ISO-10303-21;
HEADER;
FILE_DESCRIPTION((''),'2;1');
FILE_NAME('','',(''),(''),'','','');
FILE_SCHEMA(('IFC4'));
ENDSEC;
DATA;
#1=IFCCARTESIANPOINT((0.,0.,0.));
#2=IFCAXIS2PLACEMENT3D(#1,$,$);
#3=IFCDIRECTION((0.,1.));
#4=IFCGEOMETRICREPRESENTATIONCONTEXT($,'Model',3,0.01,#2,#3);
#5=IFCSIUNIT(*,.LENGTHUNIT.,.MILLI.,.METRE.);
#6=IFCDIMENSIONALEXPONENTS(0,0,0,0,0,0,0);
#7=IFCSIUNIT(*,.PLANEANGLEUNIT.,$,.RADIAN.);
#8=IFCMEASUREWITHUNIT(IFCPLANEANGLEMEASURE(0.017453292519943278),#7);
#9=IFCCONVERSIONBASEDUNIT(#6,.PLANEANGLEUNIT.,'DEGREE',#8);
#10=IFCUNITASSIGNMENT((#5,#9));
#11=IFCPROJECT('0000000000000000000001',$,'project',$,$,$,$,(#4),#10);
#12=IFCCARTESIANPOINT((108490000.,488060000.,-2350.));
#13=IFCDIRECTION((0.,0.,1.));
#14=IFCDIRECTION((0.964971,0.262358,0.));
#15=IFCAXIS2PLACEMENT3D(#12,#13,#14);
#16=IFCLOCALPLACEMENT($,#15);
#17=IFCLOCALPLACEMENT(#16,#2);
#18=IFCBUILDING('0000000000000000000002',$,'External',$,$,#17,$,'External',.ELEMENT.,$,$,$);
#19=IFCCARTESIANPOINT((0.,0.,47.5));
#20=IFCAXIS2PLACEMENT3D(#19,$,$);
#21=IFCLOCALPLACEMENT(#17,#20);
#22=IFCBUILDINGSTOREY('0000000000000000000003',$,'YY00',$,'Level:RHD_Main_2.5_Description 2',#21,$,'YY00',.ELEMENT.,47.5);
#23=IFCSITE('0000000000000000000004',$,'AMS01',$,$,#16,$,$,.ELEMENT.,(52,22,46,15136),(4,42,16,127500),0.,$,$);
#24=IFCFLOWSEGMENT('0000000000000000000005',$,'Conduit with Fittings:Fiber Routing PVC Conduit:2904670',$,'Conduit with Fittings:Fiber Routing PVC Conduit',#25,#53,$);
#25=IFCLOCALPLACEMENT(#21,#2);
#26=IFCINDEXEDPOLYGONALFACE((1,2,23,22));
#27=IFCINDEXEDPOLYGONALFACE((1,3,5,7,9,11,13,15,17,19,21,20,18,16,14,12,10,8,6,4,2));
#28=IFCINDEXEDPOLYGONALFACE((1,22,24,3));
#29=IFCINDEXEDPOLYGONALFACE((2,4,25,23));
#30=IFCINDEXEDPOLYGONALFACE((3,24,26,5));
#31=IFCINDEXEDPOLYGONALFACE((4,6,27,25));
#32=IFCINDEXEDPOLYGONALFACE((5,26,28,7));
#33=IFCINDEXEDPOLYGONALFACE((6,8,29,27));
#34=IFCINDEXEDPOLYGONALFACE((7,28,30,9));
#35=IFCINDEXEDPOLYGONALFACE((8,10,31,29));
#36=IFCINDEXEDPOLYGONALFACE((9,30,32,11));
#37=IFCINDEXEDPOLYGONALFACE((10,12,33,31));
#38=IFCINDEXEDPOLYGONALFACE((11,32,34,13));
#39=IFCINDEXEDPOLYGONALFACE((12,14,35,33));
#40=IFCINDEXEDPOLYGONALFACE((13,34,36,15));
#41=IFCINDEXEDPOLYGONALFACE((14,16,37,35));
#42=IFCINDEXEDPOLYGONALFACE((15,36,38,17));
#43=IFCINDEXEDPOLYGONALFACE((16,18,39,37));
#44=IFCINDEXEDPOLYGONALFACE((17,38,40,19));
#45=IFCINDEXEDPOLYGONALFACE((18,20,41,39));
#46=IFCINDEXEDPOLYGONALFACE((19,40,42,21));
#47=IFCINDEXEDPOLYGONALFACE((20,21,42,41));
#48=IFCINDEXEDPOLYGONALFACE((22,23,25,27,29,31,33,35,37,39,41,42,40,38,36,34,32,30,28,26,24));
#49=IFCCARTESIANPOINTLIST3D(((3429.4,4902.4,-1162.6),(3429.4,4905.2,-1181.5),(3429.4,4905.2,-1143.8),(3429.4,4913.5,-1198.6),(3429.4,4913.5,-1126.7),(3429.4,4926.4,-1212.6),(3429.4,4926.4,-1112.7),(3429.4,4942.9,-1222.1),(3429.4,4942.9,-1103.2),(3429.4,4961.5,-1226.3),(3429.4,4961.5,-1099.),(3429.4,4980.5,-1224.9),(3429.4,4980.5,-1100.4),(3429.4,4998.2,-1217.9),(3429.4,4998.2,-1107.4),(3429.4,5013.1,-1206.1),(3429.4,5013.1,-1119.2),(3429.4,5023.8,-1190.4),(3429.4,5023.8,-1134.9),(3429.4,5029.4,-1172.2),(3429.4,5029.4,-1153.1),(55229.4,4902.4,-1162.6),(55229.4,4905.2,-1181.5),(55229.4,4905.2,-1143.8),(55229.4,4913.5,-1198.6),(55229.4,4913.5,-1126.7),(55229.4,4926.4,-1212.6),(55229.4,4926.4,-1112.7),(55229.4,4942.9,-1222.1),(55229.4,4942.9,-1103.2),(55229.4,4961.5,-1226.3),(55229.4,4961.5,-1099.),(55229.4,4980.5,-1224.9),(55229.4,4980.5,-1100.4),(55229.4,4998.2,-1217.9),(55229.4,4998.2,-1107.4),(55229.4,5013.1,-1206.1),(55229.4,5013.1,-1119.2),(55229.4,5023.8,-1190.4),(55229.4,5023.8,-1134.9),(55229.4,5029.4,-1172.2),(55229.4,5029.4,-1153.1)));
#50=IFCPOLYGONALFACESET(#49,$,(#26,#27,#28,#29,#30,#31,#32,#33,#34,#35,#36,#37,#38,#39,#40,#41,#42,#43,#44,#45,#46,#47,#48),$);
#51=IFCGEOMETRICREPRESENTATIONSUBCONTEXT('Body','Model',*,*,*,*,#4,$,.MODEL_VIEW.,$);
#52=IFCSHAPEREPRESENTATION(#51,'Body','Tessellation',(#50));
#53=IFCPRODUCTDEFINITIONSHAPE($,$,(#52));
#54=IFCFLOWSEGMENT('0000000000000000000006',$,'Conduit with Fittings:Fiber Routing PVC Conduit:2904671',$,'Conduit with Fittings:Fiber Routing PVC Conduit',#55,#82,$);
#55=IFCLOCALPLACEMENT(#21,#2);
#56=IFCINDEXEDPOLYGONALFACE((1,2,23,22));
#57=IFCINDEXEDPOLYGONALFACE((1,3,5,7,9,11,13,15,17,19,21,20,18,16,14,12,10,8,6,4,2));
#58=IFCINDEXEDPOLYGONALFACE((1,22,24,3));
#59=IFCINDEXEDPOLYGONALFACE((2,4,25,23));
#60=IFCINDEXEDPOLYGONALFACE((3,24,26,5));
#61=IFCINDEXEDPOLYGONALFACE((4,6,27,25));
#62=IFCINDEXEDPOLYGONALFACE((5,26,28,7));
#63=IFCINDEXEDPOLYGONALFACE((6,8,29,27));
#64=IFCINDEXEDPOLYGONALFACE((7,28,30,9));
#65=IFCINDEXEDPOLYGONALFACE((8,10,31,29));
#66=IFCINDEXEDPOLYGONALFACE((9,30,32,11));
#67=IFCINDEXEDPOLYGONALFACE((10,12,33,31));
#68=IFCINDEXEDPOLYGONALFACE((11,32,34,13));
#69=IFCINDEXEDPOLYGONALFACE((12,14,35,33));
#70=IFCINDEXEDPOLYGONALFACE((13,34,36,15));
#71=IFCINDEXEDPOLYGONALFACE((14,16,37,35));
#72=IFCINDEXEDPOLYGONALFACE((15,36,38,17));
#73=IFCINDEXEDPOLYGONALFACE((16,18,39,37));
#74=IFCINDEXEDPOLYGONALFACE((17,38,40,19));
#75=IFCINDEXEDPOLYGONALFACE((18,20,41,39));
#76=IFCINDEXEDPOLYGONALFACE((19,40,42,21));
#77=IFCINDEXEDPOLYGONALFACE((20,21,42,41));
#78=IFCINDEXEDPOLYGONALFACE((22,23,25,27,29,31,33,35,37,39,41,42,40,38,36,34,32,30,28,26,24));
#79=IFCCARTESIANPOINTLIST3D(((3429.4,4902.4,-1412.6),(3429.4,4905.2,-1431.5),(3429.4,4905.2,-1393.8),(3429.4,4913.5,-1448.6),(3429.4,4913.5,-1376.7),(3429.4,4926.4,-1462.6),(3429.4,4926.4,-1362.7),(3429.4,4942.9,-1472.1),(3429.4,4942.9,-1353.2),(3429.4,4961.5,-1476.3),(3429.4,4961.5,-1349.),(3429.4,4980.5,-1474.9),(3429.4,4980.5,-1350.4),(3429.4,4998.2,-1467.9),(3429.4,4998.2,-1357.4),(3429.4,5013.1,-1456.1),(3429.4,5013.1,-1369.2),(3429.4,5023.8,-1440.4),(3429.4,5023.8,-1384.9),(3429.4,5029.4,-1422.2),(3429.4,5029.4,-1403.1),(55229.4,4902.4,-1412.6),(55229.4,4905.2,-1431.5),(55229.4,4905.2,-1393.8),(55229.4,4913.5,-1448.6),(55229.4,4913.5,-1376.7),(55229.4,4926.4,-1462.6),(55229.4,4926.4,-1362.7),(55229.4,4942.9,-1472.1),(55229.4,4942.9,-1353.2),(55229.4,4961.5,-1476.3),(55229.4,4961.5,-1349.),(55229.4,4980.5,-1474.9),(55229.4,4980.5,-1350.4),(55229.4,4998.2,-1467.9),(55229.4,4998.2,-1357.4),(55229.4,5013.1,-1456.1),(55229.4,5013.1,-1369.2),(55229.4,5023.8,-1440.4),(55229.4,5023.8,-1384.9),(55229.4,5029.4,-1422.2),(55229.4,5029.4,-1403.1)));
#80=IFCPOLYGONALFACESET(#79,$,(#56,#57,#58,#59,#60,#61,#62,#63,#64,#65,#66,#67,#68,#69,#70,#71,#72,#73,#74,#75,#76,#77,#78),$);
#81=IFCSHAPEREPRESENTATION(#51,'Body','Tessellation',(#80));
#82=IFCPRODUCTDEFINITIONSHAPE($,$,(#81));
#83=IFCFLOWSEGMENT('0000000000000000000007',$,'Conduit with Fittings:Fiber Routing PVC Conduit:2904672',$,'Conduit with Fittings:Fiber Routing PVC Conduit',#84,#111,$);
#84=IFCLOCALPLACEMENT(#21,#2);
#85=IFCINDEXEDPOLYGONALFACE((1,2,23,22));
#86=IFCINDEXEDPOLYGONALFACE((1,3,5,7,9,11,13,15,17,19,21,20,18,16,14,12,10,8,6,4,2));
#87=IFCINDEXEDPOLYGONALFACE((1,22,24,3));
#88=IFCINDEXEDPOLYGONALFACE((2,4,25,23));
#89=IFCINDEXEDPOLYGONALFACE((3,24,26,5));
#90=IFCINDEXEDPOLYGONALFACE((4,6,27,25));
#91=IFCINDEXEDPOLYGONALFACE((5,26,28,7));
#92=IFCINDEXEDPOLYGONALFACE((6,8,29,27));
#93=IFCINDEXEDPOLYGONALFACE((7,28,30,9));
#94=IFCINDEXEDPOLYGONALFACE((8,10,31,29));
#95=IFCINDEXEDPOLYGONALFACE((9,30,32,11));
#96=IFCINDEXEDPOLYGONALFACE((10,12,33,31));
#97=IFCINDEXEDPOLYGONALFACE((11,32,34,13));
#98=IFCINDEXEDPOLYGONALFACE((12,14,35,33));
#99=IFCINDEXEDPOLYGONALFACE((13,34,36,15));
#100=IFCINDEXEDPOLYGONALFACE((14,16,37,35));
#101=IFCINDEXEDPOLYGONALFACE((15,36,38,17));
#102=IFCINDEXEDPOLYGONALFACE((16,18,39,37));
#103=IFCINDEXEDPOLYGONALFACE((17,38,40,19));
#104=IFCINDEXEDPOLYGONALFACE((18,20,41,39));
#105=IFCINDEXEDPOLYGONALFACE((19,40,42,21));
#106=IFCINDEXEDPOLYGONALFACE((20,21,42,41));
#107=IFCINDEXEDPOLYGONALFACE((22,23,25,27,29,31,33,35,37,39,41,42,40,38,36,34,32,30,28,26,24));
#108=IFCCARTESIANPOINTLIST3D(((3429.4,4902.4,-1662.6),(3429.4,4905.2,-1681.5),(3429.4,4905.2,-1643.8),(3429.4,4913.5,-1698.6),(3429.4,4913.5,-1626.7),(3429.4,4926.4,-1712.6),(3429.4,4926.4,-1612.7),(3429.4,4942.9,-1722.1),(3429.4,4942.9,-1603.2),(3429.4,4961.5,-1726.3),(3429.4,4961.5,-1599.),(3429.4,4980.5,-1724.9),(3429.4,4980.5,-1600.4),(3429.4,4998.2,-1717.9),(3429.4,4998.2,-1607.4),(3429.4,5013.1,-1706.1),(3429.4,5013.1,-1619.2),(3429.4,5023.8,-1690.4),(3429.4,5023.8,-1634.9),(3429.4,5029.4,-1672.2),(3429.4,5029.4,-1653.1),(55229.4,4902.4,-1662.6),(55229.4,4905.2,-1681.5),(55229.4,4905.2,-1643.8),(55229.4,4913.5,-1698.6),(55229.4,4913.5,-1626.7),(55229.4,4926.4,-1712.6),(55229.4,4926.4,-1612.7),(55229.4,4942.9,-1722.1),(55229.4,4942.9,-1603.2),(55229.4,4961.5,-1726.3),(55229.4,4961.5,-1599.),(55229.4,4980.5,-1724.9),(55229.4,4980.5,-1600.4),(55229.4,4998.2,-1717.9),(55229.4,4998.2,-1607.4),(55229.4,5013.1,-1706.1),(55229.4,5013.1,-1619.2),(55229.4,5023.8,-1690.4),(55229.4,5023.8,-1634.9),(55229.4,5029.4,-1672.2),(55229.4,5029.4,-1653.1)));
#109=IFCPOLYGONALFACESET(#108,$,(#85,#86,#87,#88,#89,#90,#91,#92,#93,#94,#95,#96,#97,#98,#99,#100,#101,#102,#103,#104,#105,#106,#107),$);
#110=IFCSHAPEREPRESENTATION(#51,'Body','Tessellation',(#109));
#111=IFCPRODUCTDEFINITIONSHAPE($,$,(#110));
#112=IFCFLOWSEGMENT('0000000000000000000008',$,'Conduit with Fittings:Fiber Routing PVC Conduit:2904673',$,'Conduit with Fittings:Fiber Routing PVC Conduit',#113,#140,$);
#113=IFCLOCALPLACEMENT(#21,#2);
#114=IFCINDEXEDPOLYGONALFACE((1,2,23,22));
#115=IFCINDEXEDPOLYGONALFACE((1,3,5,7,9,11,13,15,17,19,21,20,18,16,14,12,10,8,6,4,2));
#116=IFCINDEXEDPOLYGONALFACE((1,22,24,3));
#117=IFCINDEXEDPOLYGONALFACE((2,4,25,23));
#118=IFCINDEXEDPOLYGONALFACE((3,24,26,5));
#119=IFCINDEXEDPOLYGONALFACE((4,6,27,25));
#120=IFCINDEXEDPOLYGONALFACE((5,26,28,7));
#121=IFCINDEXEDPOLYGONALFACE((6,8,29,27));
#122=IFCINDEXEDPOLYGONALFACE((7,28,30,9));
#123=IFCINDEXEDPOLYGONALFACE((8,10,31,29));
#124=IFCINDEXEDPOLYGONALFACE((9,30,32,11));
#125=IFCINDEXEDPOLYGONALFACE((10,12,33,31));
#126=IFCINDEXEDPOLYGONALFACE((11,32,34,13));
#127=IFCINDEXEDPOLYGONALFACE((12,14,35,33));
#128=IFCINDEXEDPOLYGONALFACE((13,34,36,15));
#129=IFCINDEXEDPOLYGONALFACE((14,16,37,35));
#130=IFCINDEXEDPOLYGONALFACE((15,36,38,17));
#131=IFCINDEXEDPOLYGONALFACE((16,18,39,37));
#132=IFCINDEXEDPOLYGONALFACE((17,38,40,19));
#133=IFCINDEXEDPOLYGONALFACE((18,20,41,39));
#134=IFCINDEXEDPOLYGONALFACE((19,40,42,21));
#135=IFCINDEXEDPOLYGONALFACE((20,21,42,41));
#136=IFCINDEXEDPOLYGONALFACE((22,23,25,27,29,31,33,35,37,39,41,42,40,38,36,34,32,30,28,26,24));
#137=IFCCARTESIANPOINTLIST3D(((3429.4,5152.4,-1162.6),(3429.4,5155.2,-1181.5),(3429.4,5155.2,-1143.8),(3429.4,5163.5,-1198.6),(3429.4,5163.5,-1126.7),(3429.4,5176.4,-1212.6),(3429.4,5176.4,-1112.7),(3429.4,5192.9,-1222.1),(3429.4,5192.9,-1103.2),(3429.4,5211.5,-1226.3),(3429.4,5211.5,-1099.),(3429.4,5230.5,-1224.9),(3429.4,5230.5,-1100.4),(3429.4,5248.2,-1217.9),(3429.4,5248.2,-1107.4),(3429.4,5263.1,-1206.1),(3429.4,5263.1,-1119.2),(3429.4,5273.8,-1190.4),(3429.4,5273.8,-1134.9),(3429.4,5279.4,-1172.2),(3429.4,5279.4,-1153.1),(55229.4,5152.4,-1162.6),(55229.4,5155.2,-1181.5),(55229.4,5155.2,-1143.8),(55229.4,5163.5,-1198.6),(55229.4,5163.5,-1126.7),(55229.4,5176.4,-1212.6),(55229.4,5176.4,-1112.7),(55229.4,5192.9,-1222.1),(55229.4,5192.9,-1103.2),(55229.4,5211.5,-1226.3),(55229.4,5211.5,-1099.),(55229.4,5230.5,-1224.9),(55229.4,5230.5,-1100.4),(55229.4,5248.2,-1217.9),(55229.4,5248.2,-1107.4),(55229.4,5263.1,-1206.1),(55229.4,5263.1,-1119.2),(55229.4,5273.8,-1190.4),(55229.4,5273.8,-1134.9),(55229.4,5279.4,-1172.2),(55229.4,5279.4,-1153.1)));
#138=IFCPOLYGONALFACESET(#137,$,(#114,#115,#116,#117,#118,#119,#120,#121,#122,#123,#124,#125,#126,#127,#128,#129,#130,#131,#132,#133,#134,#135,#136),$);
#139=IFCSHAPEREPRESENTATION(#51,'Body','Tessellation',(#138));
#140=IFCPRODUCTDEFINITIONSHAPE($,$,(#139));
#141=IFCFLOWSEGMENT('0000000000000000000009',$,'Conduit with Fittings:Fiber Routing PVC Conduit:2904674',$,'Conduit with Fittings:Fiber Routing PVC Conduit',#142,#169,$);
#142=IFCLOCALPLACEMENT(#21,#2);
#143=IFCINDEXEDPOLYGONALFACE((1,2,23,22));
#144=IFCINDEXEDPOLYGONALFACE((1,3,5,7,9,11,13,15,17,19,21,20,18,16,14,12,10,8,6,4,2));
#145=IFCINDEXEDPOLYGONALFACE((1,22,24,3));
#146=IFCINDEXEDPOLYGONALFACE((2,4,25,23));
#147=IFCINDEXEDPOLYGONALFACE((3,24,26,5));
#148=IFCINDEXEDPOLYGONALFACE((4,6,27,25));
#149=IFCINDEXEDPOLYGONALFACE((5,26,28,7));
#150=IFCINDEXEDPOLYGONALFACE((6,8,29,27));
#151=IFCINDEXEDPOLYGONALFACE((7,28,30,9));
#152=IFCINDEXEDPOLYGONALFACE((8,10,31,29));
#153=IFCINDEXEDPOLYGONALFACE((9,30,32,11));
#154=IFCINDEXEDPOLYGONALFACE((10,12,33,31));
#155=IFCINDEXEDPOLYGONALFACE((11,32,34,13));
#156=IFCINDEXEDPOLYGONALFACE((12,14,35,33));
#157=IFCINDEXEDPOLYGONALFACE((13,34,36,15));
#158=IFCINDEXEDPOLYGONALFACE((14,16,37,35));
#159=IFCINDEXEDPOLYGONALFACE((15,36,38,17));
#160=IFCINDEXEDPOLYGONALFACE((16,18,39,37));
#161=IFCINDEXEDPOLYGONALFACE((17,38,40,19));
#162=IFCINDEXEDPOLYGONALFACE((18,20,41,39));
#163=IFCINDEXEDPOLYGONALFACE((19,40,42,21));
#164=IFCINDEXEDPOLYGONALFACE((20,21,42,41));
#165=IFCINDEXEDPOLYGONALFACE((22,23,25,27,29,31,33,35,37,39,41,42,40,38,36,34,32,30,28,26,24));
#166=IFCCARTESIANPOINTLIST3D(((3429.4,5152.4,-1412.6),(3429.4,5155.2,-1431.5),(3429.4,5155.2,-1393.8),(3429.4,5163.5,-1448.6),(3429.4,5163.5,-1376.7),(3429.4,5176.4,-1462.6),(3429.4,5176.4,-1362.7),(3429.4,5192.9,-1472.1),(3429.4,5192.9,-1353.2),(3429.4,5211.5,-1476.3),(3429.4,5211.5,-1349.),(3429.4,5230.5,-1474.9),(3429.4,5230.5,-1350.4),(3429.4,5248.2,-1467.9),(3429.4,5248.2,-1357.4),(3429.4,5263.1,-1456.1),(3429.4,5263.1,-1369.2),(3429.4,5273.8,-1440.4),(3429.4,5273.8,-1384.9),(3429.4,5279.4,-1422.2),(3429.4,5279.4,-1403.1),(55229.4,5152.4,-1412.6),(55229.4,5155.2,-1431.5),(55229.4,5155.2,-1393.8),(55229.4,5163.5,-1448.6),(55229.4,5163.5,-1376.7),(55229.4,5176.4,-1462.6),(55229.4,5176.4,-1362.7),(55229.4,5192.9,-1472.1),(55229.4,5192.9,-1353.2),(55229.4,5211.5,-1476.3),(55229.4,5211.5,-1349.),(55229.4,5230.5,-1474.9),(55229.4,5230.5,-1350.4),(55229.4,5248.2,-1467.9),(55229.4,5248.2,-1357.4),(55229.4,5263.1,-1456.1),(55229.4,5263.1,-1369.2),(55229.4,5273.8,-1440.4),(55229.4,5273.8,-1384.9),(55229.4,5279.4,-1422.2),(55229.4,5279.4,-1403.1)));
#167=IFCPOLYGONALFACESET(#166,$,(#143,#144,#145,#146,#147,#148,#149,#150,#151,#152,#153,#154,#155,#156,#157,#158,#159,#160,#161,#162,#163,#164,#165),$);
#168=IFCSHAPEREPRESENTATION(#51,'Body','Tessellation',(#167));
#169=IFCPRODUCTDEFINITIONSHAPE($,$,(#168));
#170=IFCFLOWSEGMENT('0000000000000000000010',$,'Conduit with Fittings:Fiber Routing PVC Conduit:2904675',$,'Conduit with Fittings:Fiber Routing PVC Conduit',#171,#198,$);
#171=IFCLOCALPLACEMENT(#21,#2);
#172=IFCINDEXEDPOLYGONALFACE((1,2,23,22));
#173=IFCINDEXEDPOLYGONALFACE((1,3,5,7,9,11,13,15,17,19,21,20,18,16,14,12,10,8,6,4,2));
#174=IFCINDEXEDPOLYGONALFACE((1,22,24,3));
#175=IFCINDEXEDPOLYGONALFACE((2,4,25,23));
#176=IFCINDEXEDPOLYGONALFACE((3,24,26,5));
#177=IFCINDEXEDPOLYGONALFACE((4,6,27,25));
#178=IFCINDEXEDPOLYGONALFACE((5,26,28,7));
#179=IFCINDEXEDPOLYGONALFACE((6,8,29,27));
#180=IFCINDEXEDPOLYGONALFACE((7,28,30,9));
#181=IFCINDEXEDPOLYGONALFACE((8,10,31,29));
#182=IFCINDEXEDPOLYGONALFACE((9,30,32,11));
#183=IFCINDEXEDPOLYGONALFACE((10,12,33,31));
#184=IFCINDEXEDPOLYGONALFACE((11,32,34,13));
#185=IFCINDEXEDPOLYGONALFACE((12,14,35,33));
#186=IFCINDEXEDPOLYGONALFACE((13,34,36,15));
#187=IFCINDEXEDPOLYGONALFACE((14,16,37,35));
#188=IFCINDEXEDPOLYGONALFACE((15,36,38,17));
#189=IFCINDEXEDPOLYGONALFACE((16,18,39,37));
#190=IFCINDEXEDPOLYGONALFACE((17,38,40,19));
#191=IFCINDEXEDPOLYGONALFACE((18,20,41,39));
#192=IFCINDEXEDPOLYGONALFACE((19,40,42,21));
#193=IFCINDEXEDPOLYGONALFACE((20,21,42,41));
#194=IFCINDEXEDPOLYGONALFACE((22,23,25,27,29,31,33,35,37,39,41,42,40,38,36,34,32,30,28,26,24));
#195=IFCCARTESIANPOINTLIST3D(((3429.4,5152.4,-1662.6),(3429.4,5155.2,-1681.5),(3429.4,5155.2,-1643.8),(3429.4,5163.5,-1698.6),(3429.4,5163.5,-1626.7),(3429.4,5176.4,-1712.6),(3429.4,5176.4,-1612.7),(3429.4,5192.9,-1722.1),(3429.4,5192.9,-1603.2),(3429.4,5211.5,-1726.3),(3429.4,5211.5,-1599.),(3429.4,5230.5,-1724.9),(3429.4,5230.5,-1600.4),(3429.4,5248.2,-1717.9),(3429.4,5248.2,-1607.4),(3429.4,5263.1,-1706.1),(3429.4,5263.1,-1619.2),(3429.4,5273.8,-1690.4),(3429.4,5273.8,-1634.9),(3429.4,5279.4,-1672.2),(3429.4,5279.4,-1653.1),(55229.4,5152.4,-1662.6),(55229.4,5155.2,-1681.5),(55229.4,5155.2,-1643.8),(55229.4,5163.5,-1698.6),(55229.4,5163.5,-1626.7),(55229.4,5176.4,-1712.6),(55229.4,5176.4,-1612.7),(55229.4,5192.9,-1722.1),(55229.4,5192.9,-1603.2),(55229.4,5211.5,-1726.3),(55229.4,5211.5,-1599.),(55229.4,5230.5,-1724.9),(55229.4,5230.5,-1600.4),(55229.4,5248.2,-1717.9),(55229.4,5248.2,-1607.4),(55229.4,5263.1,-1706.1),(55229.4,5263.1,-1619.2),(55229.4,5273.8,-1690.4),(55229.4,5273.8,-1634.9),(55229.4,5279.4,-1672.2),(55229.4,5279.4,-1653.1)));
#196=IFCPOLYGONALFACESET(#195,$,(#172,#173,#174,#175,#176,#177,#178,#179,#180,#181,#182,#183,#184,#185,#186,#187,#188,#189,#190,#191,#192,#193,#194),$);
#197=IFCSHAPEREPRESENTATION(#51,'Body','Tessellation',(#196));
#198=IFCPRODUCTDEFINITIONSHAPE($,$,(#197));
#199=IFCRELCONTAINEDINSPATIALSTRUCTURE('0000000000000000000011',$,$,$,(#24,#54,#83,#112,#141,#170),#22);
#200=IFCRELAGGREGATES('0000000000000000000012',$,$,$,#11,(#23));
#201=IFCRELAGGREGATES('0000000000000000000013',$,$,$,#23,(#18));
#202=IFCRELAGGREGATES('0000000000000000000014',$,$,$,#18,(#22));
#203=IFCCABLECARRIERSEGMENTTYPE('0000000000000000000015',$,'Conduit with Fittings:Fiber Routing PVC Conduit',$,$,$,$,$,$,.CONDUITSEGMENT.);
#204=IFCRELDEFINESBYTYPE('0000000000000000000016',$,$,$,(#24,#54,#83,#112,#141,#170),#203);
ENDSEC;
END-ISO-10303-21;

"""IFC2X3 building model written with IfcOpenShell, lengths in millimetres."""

from ifc_helpers import new_model, entity, si_unit, converted_unit, direction, frame, frame_2d, origin, origin_2d_with_axis, place, context, subcontext, project, spatial, circle, extrude, type_object, element, save


model = new_model("IFC2X3")

# Units and contexts
model_context = context("Model", 3, precision=0.01, world=origin(), true_north=direction((0.0, 1.0)))
body_context = subcontext(model_context, "Body", "Model", "MODEL_VIEW")
ifc_project = project(units=[si_unit("LENGTHUNIT", "METRE", prefix="MILLI"), converted_unit("PLANEANGLEUNIT", "DEGREE", entity("IfcPlaneAngleMeasure", 0.017453292519943278), si_unit("PLANEANGLEUNIT", "RADIAN"), dimensions=[0, 0, 0, 0, 0, 0, 0])], contexts=[model_context])

# Site, building, storey
site_placement = place(None, frame((108490000.0, 488060000.0, -2350.0), z_axis=(0.0, 0.0, 1.0), x_axis=(0.964971, 0.262358, 0.0)))
site = spatial("IfcSite", under=ifc_project, at=site_placement, Name="AMS01", CompositionType="ELEMENT", RefLatitude=(52, 22, 46, 15136), RefLongitude=(4, 42, 16, 127500), RefElevation=0.0)
building_placement = place(site_placement, origin())
building = spatial("IfcBuilding", under=site, at=building_placement, Name="External", LongName="External", CompositionType="ELEMENT")
storey_placement = place(building_placement, frame((0.0, 0.0, 47.5)))
storey = spatial("IfcBuildingStorey", under=building, at=storey_placement, Name="YY00", ObjectType="Level:RHD_Main_2.5_Description 2", LongName="YY00", CompositionType="ELEMENT", Elevation=47.5)

# Flow segments
cable_carrier_segment_type = type_object("IfcCableCarrierSegmentType", Name="Conduit with Fittings:Fiber Routing PVC Conduit", PredefinedType="CONDUITSEGMENT")
flow_segment_1_placement = place(storey_placement, origin())
element("IfcFlowSegment", 1, at=flow_segment_1_placement, inside=storey, type_object=cable_carrier_segment_type, Name="Conduit with Fittings:Fiber Routing PVC Conduit:2904670", ObjectType="Conduit with Fittings:Fiber Routing PVC Conduit", context=body_context, shape_type="SweptSolid", body=[
    extrude(circle(Radius=63.9, at=frame_2d((0.0, 0.0), x_axis=(1.0, 0.0))), frame((3429.4, 4966.3, -1162.6), z_axis=(1.0, 0.0, 0.0), x_axis=(0.0, -1.0, 0.0)), (0.0, 0.0, 1.0), 51800.0),
])
flow_segment_2_placement = place(storey_placement, origin())
element("IfcFlowSegment", 2, at=flow_segment_2_placement, inside=storey, type_object=cable_carrier_segment_type, Name="Conduit with Fittings:Fiber Routing PVC Conduit:2904671", ObjectType="Conduit with Fittings:Fiber Routing PVC Conduit", context=body_context, shape_type="SweptSolid", body=[
    extrude(circle(Radius=63.9, at=origin_2d_with_axis()), frame((3429.4, 4966.3, -1412.6), z_axis=(1.0, 0.0, 0.0), x_axis=(0.0, -1.0, 0.0)), (0.0, 0.0, 1.0), 51800.0),
])
flow_segment_3_placement = place(storey_placement, origin())
element("IfcFlowSegment", 3, at=flow_segment_3_placement, inside=storey, type_object=cable_carrier_segment_type, Name="Conduit with Fittings:Fiber Routing PVC Conduit:2904672", ObjectType="Conduit with Fittings:Fiber Routing PVC Conduit", context=body_context, shape_type="SweptSolid", body=[
    extrude(circle(Radius=63.9, at=origin_2d_with_axis()), frame((3429.4, 4966.3, -1662.6), z_axis=(1.0, 0.0, 0.0), x_axis=(0.0, -1.0, 0.0)), (0.0, 0.0, 1.0), 51800.0),
])
flow_segment_4_placement = place(storey_placement, origin())
element("IfcFlowSegment", 4, at=flow_segment_4_placement, inside=storey, type_object=cable_carrier_segment_type, Name="Conduit with Fittings:Fiber Routing PVC Conduit:2904673", ObjectType="Conduit with Fittings:Fiber Routing PVC Conduit", context=body_context, shape_type="SweptSolid", body=[
    extrude(circle(Radius=63.9, at=origin_2d_with_axis()), frame((3429.4, 5216.3, -1162.6), z_axis=(1.0, 0.0, 0.0), x_axis=(0.0, -1.0, 0.0)), (0.0, 0.0, 1.0), 51800.0),
])
flow_segment_5_placement = place(storey_placement, origin())
element("IfcFlowSegment", 5, at=flow_segment_5_placement, inside=storey, type_object=cable_carrier_segment_type, Name="Conduit with Fittings:Fiber Routing PVC Conduit:2904674", ObjectType="Conduit with Fittings:Fiber Routing PVC Conduit", context=body_context, shape_type="SweptSolid", body=[
    extrude(circle(Radius=63.9, at=origin_2d_with_axis()), frame((3429.4, 5216.3, -1412.6), z_axis=(1.0, 0.0, 0.0), x_axis=(0.0, -1.0, 0.0)), (0.0, 0.0, 1.0), 51800.0),
])
flow_segment_6_placement = place(storey_placement, origin())
element("IfcFlowSegment", 6, at=flow_segment_6_placement, inside=storey, type_object=cable_carrier_segment_type, Name="Conduit with Fittings:Fiber Routing PVC Conduit:2904675", ObjectType="Conduit with Fittings:Fiber Routing PVC Conduit", context=body_context, shape_type="SweptSolid", body=[
    extrude(circle(Radius=63.9, at=origin_2d_with_axis()), frame((3429.4, 5216.3, -1662.6), z_axis=(1.0, 0.0, 0.0), x_axis=(0.0, -1.0, 0.0)), (0.0, 0.0, 1.0), 51800.0),
])

save(model, "model.ifc")
